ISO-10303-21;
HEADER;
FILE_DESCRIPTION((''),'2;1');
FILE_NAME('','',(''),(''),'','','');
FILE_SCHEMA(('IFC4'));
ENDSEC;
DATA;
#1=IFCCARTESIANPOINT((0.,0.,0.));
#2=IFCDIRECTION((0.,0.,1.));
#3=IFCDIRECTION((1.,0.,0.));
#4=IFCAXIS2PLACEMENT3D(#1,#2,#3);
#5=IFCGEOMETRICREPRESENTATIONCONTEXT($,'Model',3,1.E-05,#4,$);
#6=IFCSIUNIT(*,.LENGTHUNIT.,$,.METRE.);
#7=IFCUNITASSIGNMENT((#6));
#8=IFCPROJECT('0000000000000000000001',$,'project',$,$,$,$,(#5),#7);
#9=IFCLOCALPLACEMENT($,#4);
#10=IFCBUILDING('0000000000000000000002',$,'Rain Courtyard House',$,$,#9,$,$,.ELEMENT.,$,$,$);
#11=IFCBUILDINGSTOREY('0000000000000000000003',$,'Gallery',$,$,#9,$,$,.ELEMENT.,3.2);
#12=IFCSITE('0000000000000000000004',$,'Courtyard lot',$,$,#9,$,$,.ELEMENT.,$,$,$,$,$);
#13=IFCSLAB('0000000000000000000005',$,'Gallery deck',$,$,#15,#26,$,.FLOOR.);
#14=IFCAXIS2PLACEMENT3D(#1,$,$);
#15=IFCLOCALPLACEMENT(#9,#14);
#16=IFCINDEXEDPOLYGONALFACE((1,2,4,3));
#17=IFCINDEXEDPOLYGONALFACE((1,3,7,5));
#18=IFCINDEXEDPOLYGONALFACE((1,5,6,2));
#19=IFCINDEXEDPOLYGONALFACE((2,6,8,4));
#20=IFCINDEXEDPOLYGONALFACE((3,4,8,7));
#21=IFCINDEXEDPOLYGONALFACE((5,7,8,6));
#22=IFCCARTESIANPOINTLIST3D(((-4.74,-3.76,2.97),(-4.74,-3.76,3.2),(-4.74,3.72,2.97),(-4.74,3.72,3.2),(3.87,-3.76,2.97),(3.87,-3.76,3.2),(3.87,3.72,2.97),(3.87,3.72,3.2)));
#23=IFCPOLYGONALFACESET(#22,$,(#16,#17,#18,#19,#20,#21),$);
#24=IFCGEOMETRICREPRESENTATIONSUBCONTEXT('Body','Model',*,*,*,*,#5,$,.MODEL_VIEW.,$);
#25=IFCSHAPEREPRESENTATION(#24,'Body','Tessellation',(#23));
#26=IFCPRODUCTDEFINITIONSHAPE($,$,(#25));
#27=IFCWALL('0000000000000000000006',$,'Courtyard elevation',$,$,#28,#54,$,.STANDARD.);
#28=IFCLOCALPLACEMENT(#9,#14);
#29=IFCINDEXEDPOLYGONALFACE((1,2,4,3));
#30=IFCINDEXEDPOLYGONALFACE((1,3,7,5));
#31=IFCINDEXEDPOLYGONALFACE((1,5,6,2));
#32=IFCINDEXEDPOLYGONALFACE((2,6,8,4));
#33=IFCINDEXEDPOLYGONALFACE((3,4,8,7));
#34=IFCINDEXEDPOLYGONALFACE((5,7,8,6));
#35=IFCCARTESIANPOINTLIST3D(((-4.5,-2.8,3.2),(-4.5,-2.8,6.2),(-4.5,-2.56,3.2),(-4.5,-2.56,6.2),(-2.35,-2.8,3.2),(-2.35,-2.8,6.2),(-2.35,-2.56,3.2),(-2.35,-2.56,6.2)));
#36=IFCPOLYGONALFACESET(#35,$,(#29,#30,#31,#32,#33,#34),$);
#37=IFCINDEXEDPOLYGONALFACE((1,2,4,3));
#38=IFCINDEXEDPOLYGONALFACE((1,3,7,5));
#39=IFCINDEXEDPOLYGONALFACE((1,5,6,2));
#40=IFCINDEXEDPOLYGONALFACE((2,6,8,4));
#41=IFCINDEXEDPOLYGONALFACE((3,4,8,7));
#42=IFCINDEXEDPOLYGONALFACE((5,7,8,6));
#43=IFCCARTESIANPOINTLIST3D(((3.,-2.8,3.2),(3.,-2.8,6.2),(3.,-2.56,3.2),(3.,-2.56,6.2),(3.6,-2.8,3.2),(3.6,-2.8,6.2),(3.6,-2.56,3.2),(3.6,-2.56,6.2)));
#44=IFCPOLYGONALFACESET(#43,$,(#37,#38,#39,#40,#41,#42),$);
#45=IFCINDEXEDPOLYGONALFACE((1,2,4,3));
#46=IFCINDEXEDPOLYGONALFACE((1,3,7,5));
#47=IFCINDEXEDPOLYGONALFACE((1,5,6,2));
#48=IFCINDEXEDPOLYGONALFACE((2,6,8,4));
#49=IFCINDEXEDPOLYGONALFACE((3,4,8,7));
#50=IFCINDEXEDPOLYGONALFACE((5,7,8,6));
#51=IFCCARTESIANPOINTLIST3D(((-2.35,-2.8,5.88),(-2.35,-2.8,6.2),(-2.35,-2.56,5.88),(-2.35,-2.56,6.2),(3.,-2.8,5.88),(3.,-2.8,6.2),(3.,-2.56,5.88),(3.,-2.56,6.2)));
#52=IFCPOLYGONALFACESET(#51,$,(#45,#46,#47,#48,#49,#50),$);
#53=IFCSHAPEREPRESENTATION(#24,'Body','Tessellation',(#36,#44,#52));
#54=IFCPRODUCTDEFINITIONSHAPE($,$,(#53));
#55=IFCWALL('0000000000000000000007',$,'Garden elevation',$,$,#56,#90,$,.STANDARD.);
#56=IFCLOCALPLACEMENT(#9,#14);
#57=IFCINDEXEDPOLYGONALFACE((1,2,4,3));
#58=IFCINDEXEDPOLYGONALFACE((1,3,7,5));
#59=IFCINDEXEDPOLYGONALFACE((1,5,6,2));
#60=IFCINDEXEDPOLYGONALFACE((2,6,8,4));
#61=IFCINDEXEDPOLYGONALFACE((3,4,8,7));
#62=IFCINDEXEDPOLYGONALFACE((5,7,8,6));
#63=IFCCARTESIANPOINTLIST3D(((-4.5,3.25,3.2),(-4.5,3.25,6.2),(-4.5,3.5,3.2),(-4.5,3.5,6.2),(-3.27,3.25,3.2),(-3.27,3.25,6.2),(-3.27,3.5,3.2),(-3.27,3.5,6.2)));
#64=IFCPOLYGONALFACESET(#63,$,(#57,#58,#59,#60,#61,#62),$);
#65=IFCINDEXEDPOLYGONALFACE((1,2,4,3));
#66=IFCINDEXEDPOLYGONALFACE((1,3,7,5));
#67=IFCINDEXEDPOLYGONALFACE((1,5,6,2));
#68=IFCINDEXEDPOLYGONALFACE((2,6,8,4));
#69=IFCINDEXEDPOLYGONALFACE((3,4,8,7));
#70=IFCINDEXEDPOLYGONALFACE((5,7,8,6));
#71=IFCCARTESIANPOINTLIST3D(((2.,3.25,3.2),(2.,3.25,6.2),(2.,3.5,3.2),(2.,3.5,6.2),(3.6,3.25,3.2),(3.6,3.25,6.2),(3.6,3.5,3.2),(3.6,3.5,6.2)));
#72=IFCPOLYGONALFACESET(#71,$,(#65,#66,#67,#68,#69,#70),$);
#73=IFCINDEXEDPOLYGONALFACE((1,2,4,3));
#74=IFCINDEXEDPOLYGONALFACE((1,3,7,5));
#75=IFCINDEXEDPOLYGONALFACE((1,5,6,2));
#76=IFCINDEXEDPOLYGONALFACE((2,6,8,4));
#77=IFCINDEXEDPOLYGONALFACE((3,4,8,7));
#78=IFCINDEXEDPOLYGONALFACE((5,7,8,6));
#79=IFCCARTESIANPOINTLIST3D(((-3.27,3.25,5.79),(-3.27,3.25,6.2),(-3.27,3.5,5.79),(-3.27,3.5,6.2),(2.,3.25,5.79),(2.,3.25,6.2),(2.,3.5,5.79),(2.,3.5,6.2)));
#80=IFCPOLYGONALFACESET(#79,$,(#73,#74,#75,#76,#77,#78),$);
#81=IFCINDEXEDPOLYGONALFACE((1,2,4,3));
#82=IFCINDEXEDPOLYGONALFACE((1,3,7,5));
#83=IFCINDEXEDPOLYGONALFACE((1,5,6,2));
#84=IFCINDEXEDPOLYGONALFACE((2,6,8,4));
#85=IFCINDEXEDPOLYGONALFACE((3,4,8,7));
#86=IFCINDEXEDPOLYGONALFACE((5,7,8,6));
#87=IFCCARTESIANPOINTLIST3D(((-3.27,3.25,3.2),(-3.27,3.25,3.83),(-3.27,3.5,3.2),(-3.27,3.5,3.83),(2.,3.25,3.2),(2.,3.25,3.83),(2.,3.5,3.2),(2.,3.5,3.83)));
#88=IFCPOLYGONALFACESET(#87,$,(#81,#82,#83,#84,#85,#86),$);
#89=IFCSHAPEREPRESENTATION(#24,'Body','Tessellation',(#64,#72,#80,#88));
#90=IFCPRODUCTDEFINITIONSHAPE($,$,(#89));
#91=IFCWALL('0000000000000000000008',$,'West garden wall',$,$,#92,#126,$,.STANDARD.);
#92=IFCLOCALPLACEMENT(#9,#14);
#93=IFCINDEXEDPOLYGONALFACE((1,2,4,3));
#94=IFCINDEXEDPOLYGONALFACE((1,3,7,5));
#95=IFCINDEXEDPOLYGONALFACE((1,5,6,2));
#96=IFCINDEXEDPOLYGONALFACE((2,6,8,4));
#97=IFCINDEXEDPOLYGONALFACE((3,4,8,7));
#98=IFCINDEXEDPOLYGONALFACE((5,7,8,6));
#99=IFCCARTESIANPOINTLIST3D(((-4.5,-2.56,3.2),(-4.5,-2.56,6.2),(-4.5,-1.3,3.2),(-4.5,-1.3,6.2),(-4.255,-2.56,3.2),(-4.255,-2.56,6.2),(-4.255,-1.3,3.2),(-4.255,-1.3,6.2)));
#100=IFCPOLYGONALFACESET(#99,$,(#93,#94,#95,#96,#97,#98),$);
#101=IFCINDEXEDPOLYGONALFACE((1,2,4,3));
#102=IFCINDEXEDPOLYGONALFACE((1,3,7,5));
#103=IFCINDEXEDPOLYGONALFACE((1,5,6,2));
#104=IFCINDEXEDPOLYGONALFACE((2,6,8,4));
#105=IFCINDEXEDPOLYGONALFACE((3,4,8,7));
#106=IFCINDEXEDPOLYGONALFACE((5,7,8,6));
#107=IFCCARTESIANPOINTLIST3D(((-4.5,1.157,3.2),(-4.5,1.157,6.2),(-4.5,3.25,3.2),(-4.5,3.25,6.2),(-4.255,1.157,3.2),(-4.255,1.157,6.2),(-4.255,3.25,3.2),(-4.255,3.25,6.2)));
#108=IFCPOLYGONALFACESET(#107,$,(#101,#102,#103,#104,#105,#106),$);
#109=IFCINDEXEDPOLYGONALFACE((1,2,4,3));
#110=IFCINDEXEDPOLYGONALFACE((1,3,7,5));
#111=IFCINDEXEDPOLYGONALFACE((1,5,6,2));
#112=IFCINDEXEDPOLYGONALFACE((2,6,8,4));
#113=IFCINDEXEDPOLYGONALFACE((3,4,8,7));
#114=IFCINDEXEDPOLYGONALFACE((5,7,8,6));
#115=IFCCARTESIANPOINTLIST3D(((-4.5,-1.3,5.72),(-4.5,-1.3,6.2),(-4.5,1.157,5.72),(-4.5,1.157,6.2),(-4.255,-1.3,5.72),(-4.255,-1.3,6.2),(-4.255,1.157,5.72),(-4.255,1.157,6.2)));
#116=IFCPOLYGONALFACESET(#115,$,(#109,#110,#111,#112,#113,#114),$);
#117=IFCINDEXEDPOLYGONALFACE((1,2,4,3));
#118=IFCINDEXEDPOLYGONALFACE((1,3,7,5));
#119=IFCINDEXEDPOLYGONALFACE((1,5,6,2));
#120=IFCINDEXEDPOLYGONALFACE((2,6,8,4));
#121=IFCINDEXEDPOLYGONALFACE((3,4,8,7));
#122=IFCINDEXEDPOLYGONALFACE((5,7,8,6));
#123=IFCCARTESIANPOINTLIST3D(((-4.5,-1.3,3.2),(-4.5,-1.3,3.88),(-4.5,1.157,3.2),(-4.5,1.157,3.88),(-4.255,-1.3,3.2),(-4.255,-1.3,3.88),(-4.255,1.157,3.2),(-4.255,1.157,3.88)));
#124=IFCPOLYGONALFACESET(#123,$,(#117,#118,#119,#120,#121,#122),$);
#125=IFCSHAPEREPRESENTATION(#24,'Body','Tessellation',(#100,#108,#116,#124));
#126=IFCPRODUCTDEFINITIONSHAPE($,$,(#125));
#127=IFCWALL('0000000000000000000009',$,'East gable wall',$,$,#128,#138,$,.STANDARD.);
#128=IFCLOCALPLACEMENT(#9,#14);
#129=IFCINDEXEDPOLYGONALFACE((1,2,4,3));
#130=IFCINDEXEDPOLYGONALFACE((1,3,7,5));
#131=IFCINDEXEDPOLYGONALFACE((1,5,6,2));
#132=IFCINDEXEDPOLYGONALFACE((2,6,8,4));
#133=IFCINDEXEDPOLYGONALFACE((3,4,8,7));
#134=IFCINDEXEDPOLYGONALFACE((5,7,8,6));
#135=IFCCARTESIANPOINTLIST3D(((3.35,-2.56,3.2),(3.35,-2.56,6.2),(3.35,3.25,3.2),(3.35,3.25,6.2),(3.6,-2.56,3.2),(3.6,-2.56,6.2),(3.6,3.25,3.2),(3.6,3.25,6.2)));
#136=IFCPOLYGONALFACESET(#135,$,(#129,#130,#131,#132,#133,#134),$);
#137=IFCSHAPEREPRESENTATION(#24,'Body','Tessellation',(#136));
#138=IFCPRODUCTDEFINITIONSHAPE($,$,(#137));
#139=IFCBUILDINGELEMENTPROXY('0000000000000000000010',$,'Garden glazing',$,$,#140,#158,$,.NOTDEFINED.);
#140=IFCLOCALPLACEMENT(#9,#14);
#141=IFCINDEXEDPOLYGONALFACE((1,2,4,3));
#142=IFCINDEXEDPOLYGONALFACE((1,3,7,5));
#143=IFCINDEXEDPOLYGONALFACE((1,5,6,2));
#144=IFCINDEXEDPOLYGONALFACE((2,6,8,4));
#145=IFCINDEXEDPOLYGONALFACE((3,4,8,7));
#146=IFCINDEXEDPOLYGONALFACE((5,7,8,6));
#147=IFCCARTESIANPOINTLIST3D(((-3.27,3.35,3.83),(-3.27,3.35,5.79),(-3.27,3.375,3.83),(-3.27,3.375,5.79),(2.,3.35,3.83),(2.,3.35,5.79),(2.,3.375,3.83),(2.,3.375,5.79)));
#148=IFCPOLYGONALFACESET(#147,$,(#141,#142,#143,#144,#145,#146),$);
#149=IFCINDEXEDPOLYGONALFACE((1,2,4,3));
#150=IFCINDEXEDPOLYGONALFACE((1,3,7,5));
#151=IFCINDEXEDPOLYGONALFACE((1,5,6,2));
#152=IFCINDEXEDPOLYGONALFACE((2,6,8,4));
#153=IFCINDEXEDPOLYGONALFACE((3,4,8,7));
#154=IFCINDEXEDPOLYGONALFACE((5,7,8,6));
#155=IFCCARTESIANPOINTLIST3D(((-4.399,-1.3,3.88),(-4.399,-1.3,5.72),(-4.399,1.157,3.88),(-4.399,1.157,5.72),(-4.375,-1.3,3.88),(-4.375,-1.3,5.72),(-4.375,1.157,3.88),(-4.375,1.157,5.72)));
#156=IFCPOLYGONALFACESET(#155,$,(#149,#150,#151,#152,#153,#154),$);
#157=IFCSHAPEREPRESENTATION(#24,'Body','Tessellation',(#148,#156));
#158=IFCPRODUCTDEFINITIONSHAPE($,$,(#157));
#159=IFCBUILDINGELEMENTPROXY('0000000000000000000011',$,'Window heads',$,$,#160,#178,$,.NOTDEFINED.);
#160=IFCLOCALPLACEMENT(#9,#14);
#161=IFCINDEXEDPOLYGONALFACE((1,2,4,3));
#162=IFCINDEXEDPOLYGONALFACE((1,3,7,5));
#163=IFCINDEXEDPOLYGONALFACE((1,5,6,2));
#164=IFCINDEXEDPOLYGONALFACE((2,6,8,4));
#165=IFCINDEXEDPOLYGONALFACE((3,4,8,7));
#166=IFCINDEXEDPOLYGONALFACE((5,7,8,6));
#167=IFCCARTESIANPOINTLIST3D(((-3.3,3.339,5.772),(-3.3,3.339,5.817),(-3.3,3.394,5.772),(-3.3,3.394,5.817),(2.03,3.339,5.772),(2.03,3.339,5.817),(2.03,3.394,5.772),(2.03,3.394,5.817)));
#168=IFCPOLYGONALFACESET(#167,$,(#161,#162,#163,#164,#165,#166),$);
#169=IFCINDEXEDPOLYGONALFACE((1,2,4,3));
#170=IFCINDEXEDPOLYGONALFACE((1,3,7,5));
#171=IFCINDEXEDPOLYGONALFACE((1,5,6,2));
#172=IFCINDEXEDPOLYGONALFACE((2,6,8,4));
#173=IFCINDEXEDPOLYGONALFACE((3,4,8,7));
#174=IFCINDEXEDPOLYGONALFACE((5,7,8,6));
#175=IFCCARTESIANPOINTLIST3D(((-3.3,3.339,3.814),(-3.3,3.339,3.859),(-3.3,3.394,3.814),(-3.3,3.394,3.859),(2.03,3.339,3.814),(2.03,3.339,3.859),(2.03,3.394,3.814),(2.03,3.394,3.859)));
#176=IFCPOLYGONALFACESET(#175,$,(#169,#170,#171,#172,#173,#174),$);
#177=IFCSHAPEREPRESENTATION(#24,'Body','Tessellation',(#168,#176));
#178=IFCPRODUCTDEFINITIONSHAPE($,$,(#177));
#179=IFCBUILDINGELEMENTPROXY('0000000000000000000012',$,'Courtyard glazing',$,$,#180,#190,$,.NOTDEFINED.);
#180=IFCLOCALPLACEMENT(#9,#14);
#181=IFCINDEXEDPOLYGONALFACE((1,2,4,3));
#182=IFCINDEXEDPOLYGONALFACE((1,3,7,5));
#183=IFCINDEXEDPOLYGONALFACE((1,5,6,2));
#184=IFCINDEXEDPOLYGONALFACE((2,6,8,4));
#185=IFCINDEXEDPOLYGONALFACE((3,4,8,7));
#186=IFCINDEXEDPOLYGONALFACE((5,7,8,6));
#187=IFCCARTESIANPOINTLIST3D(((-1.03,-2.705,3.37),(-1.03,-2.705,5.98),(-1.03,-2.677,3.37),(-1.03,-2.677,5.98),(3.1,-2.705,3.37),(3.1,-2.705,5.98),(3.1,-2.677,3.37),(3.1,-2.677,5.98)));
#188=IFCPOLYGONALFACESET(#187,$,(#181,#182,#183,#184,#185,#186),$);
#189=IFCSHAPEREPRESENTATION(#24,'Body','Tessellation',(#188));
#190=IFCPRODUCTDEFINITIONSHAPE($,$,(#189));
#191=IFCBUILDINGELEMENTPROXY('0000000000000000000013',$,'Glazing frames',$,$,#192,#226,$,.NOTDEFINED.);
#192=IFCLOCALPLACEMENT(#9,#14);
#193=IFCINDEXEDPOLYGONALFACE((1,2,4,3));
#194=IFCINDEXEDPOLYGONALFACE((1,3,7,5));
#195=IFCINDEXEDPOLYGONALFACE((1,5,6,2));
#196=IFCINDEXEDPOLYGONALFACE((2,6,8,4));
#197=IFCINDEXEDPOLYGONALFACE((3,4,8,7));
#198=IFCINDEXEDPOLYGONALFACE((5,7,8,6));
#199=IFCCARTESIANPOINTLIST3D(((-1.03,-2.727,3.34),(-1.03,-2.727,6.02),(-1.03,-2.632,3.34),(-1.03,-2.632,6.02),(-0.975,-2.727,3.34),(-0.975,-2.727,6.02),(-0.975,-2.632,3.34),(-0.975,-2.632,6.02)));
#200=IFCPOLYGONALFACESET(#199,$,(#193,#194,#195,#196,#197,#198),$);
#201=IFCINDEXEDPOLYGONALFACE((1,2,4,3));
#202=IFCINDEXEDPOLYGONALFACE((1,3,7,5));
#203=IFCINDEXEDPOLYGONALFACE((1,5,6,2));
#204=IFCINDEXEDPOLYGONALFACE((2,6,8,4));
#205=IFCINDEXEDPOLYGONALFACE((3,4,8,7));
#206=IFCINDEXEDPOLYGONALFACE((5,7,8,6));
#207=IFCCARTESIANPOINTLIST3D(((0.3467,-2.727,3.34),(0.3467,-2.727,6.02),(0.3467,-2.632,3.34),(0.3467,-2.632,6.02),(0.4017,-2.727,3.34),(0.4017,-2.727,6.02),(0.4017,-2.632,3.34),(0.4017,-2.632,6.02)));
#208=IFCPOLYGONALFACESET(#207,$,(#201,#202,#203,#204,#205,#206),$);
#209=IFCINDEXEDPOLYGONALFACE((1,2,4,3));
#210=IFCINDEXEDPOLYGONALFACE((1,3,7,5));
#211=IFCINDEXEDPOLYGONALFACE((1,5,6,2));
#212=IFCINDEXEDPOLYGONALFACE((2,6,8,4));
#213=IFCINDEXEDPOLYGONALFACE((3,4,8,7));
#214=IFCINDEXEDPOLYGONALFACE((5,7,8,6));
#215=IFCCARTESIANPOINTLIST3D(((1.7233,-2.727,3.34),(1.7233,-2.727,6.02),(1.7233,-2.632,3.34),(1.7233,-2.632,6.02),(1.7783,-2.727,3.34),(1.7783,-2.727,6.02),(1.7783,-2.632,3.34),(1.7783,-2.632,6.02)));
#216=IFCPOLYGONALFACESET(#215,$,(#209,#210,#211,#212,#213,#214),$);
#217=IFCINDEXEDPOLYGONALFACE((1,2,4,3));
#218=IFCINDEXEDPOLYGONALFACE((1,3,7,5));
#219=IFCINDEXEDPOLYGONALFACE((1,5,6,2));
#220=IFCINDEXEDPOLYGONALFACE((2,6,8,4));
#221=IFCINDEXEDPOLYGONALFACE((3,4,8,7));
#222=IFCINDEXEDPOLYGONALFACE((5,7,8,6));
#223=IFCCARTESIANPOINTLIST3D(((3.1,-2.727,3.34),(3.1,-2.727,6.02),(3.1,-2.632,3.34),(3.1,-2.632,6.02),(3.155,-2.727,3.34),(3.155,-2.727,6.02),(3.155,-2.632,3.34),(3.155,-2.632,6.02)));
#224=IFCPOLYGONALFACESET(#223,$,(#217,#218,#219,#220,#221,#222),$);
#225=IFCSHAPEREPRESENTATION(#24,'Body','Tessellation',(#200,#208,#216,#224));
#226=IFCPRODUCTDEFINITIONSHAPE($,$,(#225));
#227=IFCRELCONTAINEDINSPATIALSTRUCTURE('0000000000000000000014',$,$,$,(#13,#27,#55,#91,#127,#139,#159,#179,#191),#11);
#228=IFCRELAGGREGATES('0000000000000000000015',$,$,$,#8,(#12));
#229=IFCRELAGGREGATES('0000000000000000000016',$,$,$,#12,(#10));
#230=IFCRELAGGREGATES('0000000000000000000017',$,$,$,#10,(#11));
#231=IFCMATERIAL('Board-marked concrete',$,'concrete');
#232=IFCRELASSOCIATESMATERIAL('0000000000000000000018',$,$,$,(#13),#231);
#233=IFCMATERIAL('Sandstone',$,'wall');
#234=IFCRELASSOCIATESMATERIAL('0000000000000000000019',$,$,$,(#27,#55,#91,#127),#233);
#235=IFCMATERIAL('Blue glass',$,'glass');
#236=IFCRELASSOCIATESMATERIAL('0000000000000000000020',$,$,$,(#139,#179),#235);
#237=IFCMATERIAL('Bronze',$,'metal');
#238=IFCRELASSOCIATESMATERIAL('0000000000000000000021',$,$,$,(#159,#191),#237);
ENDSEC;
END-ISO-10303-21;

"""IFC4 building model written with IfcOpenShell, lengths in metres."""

from ifc_helpers import new_model, si_unit, frame, origin_with_axes, origin_2d, place, context, subcontext, project, spatial, rectangle, extrude, material, element, save


model = new_model("IFC4")

# Units and contexts
model_context = context("Model", 3, precision=1e-05, world=origin_with_axes())
body_context = subcontext(model_context, "Body", "Model", "MODEL_VIEW")
ifc_project = project(units=[si_unit("LENGTHUNIT", "METRE")], contexts=[model_context])

# Site, building, storey
placement = place(None, origin_with_axes())
site = spatial("IfcSite", under=ifc_project, at=placement, Name="Courtyard lot", CompositionType="ELEMENT")
building = spatial("IfcBuilding", under=site, at=placement, Name="Rain Courtyard House", CompositionType="ELEMENT")
storey = spatial("IfcBuildingStorey", under=building, at=placement, Name="Gallery", CompositionType="ELEMENT", Elevation=3.2)

# Slab
ifc_material_1 = material(Name="Board-marked concrete", Category="concrete")
element("IfcSlab", 1, at=placement, inside=storey, material=ifc_material_1, Name="Gallery deck", PredefinedType="FLOOR", context=body_context, shape_type="SweptSolid", body=[
    extrude(rectangle(XDim=8.61, YDim=7.48, at=origin_2d()), frame((-0.435, -0.02, 2.97), z_axis=(0.0, 0.0, 1.0), x_axis=(1.0, 0.0, 0.0)), (0.0, 0.0, 1.0), 0.23),
])

# Walls
ifc_material_2 = material(Name="Sandstone", Category="wall")
element("IfcWall", 2, at=placement, inside=storey, material=ifc_material_2, Name="Courtyard elevation", PredefinedType="STANDARD", context=body_context, shape_type="SweptSolid", body=[
    extrude(rectangle(XDim=2.15, YDim=0.24, at=origin_2d()), frame((-3.425, -2.68, 3.2), z_axis=(0.0, 0.0, 1.0), x_axis=(1.0, 0.0, 0.0)), (0.0, 0.0, 1.0), 3.0),
    extrude(rectangle(XDim=0.6, YDim=0.24, at=origin_2d()), frame((3.3, -2.68, 3.2), z_axis=(0.0, 0.0, 1.0), x_axis=(1.0, 0.0, 0.0)), (0.0, 0.0, 1.0), 3.0),
    extrude(rectangle(XDim=5.35, YDim=0.24, at=origin_2d()), frame((0.325, -2.68, 5.88), z_axis=(0.0, 0.0, 1.0), x_axis=(1.0, 0.0, 0.0)), (0.0, 0.0, 1.0), 0.32),
])
element("IfcWall", 3, at=placement, inside=storey, material=ifc_material_2, Name="Garden elevation", PredefinedType="STANDARD", context=body_context, shape_type="SweptSolid", body=[
    extrude(rectangle(XDim=1.23, YDim=0.25, at=origin_2d()), frame((-3.885, 3.375, 3.2), z_axis=(0.0, 0.0, 1.0), x_axis=(1.0, 0.0, 0.0)), (0.0, 0.0, 1.0), 3.0),
    extrude(rectangle(XDim=1.6, YDim=0.25, at=origin_2d()), frame((2.8, 3.375, 3.2), z_axis=(0.0, 0.0, 1.0), x_axis=(1.0, 0.0, 0.0)), (0.0, 0.0, 1.0), 3.0),
    extrude(rectangle(XDim=5.27, YDim=0.25, at=origin_2d()), frame((-0.635, 3.375, 5.79), z_axis=(0.0, 0.0, 1.0), x_axis=(1.0, 0.0, 0.0)), (0.0, 0.0, 1.0), 0.41),
    extrude(rectangle(XDim=5.27, YDim=0.25, at=origin_2d()), frame((-0.635, 3.375, 3.2), z_axis=(0.0, 0.0, 1.0), x_axis=(1.0, 0.0, 0.0)), (0.0, 0.0, 1.0), 0.63),
])
element("IfcWall", 4, at=placement, inside=storey, material=ifc_material_2, Name="West garden wall", PredefinedType="STANDARD", context=body_context, shape_type="SweptSolid", body=[
    extrude(rectangle(XDim=0.245, YDim=1.26, at=origin_2d()), frame((-4.3775, -1.93, 3.2), z_axis=(0.0, 0.0, 1.0), x_axis=(1.0, 0.0, 0.0)), (0.0, 0.0, 1.0), 3.0),
    extrude(rectangle(XDim=0.245, YDim=2.093, at=origin_2d()), frame((-4.3775, 2.2035, 3.2), z_axis=(0.0, 0.0, 1.0), x_axis=(1.0, 0.0, 0.0)), (0.0, 0.0, 1.0), 3.0),
    extrude(rectangle(XDim=0.245, YDim=2.457, at=origin_2d()), frame((-4.3775, -0.0715, 5.72), z_axis=(0.0, 0.0, 1.0), x_axis=(1.0, 0.0, 0.0)), (0.0, 0.0, 1.0), 0.48),
    extrude(rectangle(XDim=0.245, YDim=2.457, at=origin_2d()), frame((-4.3775, -0.0715, 3.2), z_axis=(0.0, 0.0, 1.0), x_axis=(1.0, 0.0, 0.0)), (0.0, 0.0, 1.0), 0.68),
])
element("IfcWall", 5, at=placement, inside=storey, material=ifc_material_2, Name="East gable wall", PredefinedType="STANDARD", context=body_context, shape_type="SweptSolid", body=[
    extrude(rectangle(XDim=0.25, YDim=5.81, at=origin_2d()), frame((3.475, 0.345, 3.2), z_axis=(0.0, 0.0, 1.0), x_axis=(1.0, 0.0, 0.0)), (0.0, 0.0, 1.0), 3.0),
])

# Building element proxies
ifc_material_3 = material(Name="Blue glass", Category="glass")
element("IfcBuildingElementProxy", 6, at=placement, inside=storey, material=ifc_material_3, Name="Garden glazing", PredefinedType="NOTDEFINED", context=body_context, shape_type="SweptSolid", body=[
    extrude(rectangle(XDim=5.27, YDim=0.025, at=origin_2d()), frame((-0.635, 3.3625, 3.83), z_axis=(0.0, 0.0, 1.0), x_axis=(1.0, 0.0, 0.0)), (0.0, 0.0, 1.0), 1.96),
    extrude(rectangle(XDim=0.024, YDim=2.457, at=origin_2d()), frame((-4.387, -0.0715, 3.88), z_axis=(0.0, 0.0, 1.0), x_axis=(1.0, 0.0, 0.0)), (0.0, 0.0, 1.0), 1.84),
])
ifc_material_4 = material(Name="Bronze", Category="metal")
element("IfcBuildingElementProxy", 7, at=placement, inside=storey, material=ifc_material_4, Name="Window heads", PredefinedType="NOTDEFINED", context=body_context, shape_type="SweptSolid", body=[
    extrude(rectangle(XDim=5.33, YDim=0.055, at=origin_2d()), frame((-0.635, 3.3665, 5.772), z_axis=(0.0, 0.0, 1.0), x_axis=(1.0, 0.0, 0.0)), (0.0, 0.0, 1.0), 0.045),
    extrude(rectangle(XDim=5.33, YDim=0.055, at=origin_2d()), frame((-0.635, 3.3665, 3.814), z_axis=(0.0, 0.0, 1.0), x_axis=(1.0, 0.0, 0.0)), (0.0, 0.0, 1.0), 0.045),
])
element("IfcBuildingElementProxy", 8, at=placement, inside=storey, material=ifc_material_3, Name="Courtyard glazing", PredefinedType="NOTDEFINED", context=body_context, shape_type="SweptSolid", body=[
    extrude(rectangle(XDim=4.13, YDim=0.028, at=origin_2d()), frame((1.035, -2.691, 3.37), z_axis=(0.0, 0.0, 1.0), x_axis=(1.0, 0.0, 0.0)), (0.0, 0.0, 1.0), 2.61),
])
element("IfcBuildingElementProxy", 9, at=placement, inside=storey, material=ifc_material_4, Name="Glazing frames", PredefinedType="NOTDEFINED", context=body_context, shape_type="SweptSolid", body=[
    extrude(rectangle(XDim=0.055, YDim=0.095, at=origin_2d()), frame((-1.0025, -2.6795, 3.34), z_axis=(0.0, 0.0, 1.0), x_axis=(1.0, 0.0, 0.0)), (0.0, 0.0, 1.0), 2.68),
    extrude(rectangle(XDim=0.055, YDim=0.095, at=origin_2d()), frame((0.3742, -2.6795, 3.34), z_axis=(0.0, 0.0, 1.0), x_axis=(1.0, 0.0, 0.0)), (0.0, 0.0, 1.0), 2.68),
    extrude(rectangle(XDim=0.055, YDim=0.095, at=origin_2d()), frame((1.7508, -2.6795, 3.34), z_axis=(0.0, 0.0, 1.0), x_axis=(1.0, 0.0, 0.0)), (0.0, 0.0, 1.0), 2.68),
    extrude(rectangle(XDim=0.055, YDim=0.095, at=origin_2d()), frame((3.1275, -2.6795, 3.34), z_axis=(0.0, 0.0, 1.0), x_axis=(1.0, 0.0, 0.0)), (0.0, 0.0, 1.0), 2.68),
])

save(model, "model.ifc")
